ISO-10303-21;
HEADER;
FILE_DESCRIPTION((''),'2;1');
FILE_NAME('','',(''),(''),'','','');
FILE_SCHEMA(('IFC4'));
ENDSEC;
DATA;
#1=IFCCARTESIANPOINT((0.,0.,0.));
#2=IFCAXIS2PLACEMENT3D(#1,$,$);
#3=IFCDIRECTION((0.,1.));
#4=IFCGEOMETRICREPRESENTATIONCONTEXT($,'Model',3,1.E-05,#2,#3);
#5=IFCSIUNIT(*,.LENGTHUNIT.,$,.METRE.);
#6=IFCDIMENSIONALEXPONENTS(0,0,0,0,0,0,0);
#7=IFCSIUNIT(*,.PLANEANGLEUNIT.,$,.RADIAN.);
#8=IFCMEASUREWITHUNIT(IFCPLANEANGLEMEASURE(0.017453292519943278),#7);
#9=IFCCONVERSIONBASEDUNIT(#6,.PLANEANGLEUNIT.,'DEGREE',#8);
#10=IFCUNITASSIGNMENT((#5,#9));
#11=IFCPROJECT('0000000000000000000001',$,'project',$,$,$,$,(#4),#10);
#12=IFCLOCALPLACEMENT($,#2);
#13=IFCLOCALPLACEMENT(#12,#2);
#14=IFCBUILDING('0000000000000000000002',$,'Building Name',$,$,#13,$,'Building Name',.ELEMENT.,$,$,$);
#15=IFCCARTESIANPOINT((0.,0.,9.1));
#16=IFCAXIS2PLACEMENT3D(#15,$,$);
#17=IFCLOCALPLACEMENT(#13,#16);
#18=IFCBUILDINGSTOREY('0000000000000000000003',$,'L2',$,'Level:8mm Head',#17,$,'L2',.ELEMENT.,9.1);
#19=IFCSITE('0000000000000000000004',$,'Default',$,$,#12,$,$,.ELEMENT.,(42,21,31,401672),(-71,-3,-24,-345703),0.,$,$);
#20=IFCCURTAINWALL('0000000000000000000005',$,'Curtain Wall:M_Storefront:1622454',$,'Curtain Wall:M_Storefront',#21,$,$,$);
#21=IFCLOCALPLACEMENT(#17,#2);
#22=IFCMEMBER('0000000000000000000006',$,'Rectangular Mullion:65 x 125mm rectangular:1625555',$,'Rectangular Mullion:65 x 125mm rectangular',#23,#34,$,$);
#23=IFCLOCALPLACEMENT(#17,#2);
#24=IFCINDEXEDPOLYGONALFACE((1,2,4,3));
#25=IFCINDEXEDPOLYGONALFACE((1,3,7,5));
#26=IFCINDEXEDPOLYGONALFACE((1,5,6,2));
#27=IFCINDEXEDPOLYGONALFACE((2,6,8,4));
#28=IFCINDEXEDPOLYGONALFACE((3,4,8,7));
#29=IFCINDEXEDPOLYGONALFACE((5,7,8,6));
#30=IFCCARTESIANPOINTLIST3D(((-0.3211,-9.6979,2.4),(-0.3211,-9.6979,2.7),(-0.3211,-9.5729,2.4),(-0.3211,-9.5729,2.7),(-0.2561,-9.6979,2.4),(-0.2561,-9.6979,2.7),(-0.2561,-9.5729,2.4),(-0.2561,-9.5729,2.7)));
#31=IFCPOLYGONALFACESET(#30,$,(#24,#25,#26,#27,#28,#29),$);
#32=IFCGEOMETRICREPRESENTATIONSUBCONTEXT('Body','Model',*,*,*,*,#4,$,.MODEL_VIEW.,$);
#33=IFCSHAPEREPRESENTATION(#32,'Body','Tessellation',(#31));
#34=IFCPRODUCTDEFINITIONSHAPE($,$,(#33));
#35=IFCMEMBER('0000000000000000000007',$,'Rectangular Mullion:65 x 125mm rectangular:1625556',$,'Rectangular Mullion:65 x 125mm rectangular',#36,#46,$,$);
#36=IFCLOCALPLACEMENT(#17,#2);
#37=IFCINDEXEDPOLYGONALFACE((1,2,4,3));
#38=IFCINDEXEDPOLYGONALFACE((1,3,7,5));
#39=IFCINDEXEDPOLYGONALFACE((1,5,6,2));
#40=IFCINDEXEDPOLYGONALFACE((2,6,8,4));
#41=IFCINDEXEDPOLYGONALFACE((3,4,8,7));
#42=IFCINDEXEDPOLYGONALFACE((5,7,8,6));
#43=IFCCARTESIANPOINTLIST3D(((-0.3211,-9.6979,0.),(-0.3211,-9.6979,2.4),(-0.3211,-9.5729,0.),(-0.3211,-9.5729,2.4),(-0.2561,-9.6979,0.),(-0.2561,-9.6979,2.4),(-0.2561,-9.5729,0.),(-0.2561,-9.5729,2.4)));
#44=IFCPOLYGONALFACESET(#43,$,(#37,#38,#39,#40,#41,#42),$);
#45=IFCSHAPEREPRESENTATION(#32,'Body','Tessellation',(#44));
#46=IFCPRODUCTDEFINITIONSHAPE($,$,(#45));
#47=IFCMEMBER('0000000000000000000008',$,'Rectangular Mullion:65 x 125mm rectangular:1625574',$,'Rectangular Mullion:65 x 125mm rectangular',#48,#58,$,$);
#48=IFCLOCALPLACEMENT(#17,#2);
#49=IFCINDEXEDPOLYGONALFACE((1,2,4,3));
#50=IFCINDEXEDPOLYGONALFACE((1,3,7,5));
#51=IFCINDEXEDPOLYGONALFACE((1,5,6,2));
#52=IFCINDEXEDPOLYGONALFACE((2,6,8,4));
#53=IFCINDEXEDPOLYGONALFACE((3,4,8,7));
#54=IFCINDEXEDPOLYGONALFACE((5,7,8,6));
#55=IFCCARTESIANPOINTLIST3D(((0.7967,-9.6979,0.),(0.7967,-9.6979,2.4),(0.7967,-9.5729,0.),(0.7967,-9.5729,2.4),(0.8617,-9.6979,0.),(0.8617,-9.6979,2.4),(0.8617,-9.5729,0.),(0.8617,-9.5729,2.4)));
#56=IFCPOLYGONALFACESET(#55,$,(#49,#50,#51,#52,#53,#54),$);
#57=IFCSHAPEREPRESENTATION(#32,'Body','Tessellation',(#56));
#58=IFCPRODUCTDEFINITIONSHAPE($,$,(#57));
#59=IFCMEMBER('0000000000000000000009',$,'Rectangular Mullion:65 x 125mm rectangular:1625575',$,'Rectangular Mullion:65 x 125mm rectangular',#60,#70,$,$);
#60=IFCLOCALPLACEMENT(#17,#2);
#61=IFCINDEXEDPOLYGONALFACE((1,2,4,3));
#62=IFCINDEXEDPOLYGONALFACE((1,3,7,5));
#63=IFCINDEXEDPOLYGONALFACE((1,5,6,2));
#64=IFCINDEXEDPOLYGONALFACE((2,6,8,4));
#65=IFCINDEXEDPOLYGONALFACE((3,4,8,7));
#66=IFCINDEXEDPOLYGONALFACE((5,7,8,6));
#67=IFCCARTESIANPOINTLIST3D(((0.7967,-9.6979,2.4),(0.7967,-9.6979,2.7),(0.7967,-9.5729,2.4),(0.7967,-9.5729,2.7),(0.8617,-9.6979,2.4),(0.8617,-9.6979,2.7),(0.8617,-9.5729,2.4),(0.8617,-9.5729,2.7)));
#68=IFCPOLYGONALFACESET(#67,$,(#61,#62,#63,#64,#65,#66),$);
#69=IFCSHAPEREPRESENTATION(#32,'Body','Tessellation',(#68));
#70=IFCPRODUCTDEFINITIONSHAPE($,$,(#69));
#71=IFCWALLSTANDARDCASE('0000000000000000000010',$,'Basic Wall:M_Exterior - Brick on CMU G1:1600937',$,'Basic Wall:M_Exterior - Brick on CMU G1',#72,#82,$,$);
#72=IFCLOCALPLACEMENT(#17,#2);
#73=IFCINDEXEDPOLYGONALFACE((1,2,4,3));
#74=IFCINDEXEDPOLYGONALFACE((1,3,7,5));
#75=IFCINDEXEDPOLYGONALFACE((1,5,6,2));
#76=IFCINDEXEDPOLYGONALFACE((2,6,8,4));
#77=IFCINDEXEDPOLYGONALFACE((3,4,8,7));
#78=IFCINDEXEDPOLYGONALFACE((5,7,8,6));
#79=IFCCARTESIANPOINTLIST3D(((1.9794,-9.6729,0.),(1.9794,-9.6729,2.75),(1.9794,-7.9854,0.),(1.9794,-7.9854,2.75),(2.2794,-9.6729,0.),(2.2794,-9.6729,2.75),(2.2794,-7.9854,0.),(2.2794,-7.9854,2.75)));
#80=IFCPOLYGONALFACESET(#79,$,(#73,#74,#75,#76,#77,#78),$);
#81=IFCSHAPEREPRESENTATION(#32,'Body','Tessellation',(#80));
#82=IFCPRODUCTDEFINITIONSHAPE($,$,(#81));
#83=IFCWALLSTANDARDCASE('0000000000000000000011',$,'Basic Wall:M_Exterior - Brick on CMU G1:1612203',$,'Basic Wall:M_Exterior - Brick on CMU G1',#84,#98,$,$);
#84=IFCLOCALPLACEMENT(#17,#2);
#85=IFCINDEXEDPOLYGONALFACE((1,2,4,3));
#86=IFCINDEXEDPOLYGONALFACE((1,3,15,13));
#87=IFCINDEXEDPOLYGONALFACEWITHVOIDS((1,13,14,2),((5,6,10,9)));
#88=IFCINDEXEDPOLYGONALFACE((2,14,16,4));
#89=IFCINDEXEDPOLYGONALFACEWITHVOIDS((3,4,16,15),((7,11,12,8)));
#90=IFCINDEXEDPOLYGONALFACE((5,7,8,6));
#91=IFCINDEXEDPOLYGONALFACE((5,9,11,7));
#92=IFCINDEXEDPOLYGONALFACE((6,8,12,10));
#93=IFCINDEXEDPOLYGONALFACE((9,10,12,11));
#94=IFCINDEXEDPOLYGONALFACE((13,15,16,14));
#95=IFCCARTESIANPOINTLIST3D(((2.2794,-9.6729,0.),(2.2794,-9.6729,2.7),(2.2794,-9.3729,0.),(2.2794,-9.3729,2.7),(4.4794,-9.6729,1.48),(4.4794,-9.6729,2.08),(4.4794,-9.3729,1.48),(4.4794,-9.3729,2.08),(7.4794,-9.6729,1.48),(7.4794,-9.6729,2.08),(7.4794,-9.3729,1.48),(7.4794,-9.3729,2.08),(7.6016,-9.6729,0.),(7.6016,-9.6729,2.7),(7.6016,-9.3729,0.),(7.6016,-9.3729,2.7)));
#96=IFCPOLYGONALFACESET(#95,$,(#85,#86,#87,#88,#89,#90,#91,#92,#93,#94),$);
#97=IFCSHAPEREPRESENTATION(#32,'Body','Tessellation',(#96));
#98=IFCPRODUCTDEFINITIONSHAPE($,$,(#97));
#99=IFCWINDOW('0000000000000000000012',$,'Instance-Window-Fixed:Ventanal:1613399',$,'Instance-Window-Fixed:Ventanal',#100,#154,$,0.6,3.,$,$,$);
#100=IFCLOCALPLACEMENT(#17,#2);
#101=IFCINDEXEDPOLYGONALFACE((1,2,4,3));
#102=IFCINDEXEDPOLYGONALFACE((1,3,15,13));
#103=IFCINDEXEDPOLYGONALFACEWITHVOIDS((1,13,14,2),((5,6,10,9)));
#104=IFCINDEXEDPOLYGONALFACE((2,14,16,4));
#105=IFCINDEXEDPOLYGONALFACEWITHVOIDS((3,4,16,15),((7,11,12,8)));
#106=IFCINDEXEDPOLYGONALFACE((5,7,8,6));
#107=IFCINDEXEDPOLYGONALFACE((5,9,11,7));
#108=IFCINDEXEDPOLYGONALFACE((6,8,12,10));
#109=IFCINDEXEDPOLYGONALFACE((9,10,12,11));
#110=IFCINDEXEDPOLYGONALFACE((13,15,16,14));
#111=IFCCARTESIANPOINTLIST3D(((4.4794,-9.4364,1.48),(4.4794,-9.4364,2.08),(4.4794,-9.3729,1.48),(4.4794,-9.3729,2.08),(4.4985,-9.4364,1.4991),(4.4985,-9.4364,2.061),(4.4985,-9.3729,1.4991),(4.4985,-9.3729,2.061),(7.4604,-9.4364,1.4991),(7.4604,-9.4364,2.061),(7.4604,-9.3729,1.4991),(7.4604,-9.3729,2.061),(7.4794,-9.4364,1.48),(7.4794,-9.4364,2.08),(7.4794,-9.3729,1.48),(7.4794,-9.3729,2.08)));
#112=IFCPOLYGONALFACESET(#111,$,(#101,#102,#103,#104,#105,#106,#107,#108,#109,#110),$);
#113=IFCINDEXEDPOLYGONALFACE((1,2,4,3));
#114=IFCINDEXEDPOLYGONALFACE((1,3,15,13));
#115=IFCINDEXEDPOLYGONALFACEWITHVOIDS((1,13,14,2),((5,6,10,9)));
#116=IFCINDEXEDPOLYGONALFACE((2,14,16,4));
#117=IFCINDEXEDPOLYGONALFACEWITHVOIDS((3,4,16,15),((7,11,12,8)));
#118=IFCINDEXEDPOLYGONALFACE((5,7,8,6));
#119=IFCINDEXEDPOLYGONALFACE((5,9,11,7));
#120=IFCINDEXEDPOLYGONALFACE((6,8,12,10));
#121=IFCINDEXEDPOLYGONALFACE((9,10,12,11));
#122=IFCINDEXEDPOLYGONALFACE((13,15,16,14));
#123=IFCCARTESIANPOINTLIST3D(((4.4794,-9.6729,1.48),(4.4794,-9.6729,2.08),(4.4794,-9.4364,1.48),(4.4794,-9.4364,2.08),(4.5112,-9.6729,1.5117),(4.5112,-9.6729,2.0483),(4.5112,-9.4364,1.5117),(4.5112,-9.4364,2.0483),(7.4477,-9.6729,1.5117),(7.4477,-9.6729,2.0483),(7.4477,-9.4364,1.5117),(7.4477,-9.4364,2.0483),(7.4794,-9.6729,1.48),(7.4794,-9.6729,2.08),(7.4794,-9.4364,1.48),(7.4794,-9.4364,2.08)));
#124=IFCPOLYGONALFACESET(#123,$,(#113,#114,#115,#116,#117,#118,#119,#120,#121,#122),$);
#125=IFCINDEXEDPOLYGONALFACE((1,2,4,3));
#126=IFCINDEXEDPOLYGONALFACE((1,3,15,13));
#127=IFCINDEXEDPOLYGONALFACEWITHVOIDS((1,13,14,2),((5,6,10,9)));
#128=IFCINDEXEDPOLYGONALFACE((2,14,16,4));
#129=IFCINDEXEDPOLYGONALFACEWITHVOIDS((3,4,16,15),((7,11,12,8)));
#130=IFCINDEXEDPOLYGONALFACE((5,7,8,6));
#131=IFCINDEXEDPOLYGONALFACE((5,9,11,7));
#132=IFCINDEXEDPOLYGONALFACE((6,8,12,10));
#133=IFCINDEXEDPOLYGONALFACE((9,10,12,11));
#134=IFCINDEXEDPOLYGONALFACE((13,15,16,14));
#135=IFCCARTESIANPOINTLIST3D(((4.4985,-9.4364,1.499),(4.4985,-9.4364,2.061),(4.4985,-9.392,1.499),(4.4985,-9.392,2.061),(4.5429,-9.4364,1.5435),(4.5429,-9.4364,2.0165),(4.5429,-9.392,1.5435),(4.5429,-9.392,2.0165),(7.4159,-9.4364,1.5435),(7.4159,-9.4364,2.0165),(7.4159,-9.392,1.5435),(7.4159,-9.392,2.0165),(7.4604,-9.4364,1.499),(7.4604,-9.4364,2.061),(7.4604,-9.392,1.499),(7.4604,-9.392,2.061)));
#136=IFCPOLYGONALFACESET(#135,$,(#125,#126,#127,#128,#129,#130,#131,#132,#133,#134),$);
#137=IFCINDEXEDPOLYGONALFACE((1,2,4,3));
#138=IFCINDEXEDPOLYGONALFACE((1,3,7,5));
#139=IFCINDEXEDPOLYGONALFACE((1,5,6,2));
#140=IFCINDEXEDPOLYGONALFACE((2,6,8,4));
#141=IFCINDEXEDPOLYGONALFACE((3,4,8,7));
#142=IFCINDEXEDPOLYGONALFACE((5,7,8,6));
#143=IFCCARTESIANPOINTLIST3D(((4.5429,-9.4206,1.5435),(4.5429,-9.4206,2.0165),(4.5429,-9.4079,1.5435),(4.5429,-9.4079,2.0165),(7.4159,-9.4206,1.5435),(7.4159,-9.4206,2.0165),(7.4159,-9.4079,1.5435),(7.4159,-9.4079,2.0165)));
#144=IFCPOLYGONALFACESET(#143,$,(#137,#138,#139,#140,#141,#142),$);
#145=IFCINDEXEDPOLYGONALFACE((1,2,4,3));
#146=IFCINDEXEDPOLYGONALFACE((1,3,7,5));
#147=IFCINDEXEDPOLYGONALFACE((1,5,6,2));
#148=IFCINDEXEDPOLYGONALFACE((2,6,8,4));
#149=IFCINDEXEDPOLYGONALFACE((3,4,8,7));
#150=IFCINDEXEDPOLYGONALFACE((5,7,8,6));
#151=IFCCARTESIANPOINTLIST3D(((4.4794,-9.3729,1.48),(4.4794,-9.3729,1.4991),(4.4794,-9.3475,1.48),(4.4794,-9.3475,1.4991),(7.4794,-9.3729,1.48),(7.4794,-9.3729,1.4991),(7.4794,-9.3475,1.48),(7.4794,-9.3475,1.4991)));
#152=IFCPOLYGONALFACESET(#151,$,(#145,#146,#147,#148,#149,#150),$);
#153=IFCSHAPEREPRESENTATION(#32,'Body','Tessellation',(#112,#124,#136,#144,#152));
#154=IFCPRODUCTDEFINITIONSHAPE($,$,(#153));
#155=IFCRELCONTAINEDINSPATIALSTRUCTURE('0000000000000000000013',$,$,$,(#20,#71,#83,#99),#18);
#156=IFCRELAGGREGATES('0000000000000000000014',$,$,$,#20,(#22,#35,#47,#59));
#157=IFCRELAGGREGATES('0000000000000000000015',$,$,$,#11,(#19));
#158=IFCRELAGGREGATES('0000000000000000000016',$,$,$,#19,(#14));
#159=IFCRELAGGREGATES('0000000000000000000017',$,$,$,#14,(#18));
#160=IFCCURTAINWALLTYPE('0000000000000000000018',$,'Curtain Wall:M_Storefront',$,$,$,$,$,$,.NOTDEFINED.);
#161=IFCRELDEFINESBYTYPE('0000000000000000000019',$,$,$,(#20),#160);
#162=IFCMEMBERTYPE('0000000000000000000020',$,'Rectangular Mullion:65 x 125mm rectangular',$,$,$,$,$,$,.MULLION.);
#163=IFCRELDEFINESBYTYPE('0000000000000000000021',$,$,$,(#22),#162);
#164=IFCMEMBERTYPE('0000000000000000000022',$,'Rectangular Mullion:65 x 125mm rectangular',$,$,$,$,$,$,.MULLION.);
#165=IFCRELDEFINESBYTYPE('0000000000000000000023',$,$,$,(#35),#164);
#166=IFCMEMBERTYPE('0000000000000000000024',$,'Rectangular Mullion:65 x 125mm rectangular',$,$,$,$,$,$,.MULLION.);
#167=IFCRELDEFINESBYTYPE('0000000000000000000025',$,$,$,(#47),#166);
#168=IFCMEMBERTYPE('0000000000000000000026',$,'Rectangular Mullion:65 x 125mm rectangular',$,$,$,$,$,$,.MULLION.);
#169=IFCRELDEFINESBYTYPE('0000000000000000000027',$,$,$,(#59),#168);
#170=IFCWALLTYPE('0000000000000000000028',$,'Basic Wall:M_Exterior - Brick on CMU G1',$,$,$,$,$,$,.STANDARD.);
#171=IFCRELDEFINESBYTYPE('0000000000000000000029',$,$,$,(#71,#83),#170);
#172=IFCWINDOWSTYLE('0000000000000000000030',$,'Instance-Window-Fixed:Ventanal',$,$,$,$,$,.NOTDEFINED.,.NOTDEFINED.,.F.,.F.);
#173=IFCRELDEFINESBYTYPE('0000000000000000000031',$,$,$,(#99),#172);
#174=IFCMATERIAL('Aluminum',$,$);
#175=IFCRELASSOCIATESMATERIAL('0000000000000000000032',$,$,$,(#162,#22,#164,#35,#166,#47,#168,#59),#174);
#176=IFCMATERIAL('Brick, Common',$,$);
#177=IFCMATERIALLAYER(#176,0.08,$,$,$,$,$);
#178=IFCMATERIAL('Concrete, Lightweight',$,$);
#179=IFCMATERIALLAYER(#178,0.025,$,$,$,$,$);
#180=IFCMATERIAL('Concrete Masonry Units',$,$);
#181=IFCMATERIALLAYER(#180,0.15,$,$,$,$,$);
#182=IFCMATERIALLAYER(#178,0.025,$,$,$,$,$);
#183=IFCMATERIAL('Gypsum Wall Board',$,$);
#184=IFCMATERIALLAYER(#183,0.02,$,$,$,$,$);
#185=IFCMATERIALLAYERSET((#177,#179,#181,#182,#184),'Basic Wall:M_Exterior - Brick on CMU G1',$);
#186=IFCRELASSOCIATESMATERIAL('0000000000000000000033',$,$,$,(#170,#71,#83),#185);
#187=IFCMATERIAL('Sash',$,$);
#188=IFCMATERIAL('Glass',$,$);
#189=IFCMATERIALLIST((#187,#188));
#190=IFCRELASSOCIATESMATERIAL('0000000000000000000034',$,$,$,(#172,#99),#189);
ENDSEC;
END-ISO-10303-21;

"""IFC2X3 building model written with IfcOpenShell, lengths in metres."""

from ifc_helpers import new_model, entity, si_unit, converted_unit, direction, frame, frame_2d, origin, origin_2d_with_axis, place, context, subcontext, project, spatial, polyline, rectangle, outline, extrude, source, transform, mapped, material, material_list, layer, layer_set, layer_usage, type_object, type_shapes, element, fill, aggregate, save


model = new_model("IFC2X3")

# Units and contexts
model_context = context("Model", 3, precision=1e-05, world=origin(), true_north=direction((0.0, 1.0)))
body_context = subcontext(model_context, "Body", "Model", "MODEL_VIEW")
ifc_project = project(units=[si_unit("LENGTHUNIT", "METRE"), converted_unit("PLANEANGLEUNIT", "DEGREE", entity("IfcPlaneAngleMeasure", 0.017453292519943278), si_unit("PLANEANGLEUNIT", "RADIAN"), dimensions=[0, 0, 0, 0, 0, 0, 0])], contexts=[model_context])

# Site, building, storey
site_placement = place(None, origin())
site = spatial("IfcSite", under=ifc_project, at=site_placement, Name="Default", CompositionType="ELEMENT", RefLatitude=(42, 21, 31, 401672), RefLongitude=(-71, -3, -24, -345703), RefElevation=0.0)
building_placement = place(site_placement, origin())
building = spatial("IfcBuilding", under=site, at=building_placement, Name="Building Name", LongName="Building Name", CompositionType="ELEMENT")
storey_placement = place(building_placement, frame((0.0, 0.0, 9.1)))
storey = spatial("IfcBuildingStorey", under=building, at=storey_placement, Name="L2", ObjectType="Level:8mm Head", LongName="L2", CompositionType="ELEMENT", Elevation=9.1)

# Shared definitions
ifc_material_1 = material(Name="Aluminum")

# Curtain wall, members
curtain_wall_type_1 = type_object("IfcCurtainWallType", Name="Curtain Wall:M_Storefront", PredefinedType="NOTDEFINED")
curtain_wall_1_placement = place(storey_placement, frame((0.0, 0.0, -9.1)))
curtain_wall_1 = element("IfcCurtainWall", 1, at=curtain_wall_1_placement, inside=storey, type_object=curtain_wall_type_1, Name="Curtain Wall:M_Storefront:1622454", ObjectType="Curtain Wall:M_Storefront")
member_type_1 = type_object("IfcMemberType", Name="Rectangular Mullion:65 x 125mm rectangular", PredefinedType="MULLION", material=ifc_material_1)
shared_shape_1 = source(origin(), body_context, "Body", "SweptSolid", [
    extrude(rectangle(XDim=0.065, YDim=0.125, at=origin_2d_with_axis()), frame((-0.0325, 0.0, -0.3), z_axis=(0.0, 0.0, 1.0), x_axis=(-1.0, 0.0, 0.0)), (0.0, 0.0, 1.0), 0.3),
])
type_shapes(member_type_1, [shared_shape_1])
member_1_placement = place(curtain_wall_1_placement, frame((-0.3211, -9.6354, 11.8), z_axis=(0.0, 0.0, 1.0), x_axis=(-1.0, 0.0, 0.0)))
member_1 = element("IfcMember", 2, at=member_1_placement, type_object=member_type_1, material=ifc_material_1, Name="Rectangular Mullion:65 x 125mm rectangular:1625555", ObjectType="Rectangular Mullion:65 x 125mm rectangular", context=body_context, shape_type="MappedRepresentation", body=[
    mapped(shared_shape_1, transform((0.0, 0.0, 0.0), scale=1.0)),
])
member_type_2 = type_object("IfcMemberType", Name="Rectangular Mullion:65 x 125mm rectangular", PredefinedType="MULLION", material=ifc_material_1)
shared_shape_2 = source(origin(), body_context, "Body", "SweptSolid", [
    extrude(rectangle(XDim=0.065, YDim=0.125, at=origin_2d_with_axis()), frame((-0.0325, 0.0, -2.4), z_axis=(0.0, 0.0, 1.0), x_axis=(-1.0, 0.0, 0.0)), (0.0, 0.0, 1.0), 2.4),
])
type_shapes(member_type_2, [shared_shape_2])
member_2_placement = place(curtain_wall_1_placement, frame((-0.3211, -9.6354, 11.5), z_axis=(0.0, 0.0, 1.0), x_axis=(-1.0, 0.0, 0.0)))
member_2 = element("IfcMember", 3, at=member_2_placement, type_object=member_type_2, material=ifc_material_1, Name="Rectangular Mullion:65 x 125mm rectangular:1625556", ObjectType="Rectangular Mullion:65 x 125mm rectangular", context=body_context, shape_type="MappedRepresentation", body=[
    mapped(shared_shape_2, transform((0.0, 0.0, 0.0), scale=1.0)),
])
member_type_3 = type_object("IfcMemberType", Name="Rectangular Mullion:65 x 125mm rectangular", PredefinedType="MULLION", material=ifc_material_1)
shared_shape_3 = source(origin(), body_context, "Body", "SweptSolid", [
    extrude(rectangle(XDim=0.065, YDim=0.125, at=origin_2d_with_axis()), frame((0.0, 0.0, -2.4), z_axis=(0.0, 0.0, 1.0), x_axis=(-1.0, 0.0, 0.0)), (0.0, 0.0, 1.0), 2.4),
])
type_shapes(member_type_3, [shared_shape_3])
member_3_placement = place(curtain_wall_1_placement, frame((0.8292, -9.6354, 9.1), z_axis=(0.0, 0.0, -1.0), x_axis=(1.0, 0.0, 0.0)))
member_3 = element("IfcMember", 4, at=member_3_placement, type_object=member_type_3, material=ifc_material_1, Name="Rectangular Mullion:65 x 125mm rectangular:1625574", ObjectType="Rectangular Mullion:65 x 125mm rectangular", context=body_context, shape_type="MappedRepresentation", body=[
    mapped(shared_shape_3, transform((0.0, 0.0, 0.0), scale=1.0)),
])
member_type_4 = type_object("IfcMemberType", Name="Rectangular Mullion:65 x 125mm rectangular", PredefinedType="MULLION", material=ifc_material_1)
shared_shape_4 = source(origin(), body_context, "Body", "SweptSolid", [
    extrude(rectangle(XDim=0.065, YDim=0.125, at=origin_2d_with_axis()), frame((0.0, 0.0, -0.3), z_axis=(0.0, 0.0, 1.0), x_axis=(-1.0, 0.0, 0.0)), (0.0, 0.0, 1.0), 0.3),
])
type_shapes(member_type_4, [shared_shape_4])
member_4_placement = place(curtain_wall_1_placement, frame((0.8292, -9.6354, 11.5), z_axis=(0.0, 0.0, -1.0), x_axis=(1.0, 0.0, 0.0)))
member_4 = element("IfcMember", 5, at=member_4_placement, type_object=member_type_4, material=ifc_material_1, Name="Rectangular Mullion:65 x 125mm rectangular:1625575", ObjectType="Rectangular Mullion:65 x 125mm rectangular", context=body_context, shape_type="MappedRepresentation", body=[
    mapped(shared_shape_4, transform((0.0, 0.0, 0.0), scale=1.0)),
])

# Shared definitions
ifc_material_2 = material(Name="Glass")
aggregate(curtain_wall_1, [member_1, member_2, member_3, member_4])

# Wall
ifc_material_3 = material(Name="Brick, Common")
ifc_layer_1 = layer(ifc_material_3, 0.08)
ifc_material_4 = material(Name="Concrete, Lightweight")
ifc_layer_2 = layer(ifc_material_4, 0.025)
ifc_material_5 = material(Name="Concrete Masonry Units")
ifc_layer_3 = layer(ifc_material_5, 0.15)
ifc_layer_4 = layer(ifc_material_4, 0.025)
ifc_material_6 = material(Name="Gypsum Wall Board")
ifc_layer_5 = layer(ifc_material_6, 0.02)
ifc_layer_set = layer_set([ifc_layer_1, ifc_layer_2, ifc_layer_3, ifc_layer_4, ifc_layer_5], Name="Basic Wall:M_Exterior - Brick on CMU G1")
ifc_layer_usage_1 = layer_usage(ifc_layer_set, "AXIS2", "POSITIVE", -0.15)
wall_type = type_object("IfcWallType", Name="Basic Wall:M_Exterior - Brick on CMU G1", PredefinedType="STANDARD", material=ifc_layer_set)
wall_1_placement = place(storey_placement, frame((2.1294, -9.6729, 0.0), z_axis=(0.0, 0.0, 1.0), x_axis=(0.0, 1.0, 0.0)))
element("IfcWallStandardCase", 6, at=wall_1_placement, inside=storey, type_object=wall_type, material=ifc_layer_usage_1, Name="Basic Wall:M_Exterior - Brick on CMU G1:1600937", ObjectType="Basic Wall:M_Exterior - Brick on CMU G1", context=body_context, shape_type="SweptSolid", body=[
    extrude(rectangle(XDim=1.6875, YDim=0.3, at=frame_2d((0.8438, 0.0), x_axis=(-1.0, 0.0))), origin(), (0.0, 0.0, 1.0), 2.75),
])

# Wall, opening, window
ifc_layer_usage_2 = layer_usage(ifc_layer_set, "AXIS2", "POSITIVE", -0.15)
wall_2_placement = place(storey_placement, frame((2.2794, -9.5229, 0.0)))
wall_2 = element("IfcWallStandardCase", 7, at=wall_2_placement, inside=storey, type_object=wall_type, material=ifc_layer_usage_2, Name="Basic Wall:M_Exterior - Brick on CMU G1:1612203", ObjectType="Basic Wall:M_Exterior - Brick on CMU G1", context=body_context, shape_type="SweptSolid", body=[
    extrude(rectangle(XDim=5.3222, YDim=0.3, at=frame_2d((2.6611, 0.0), x_axis=(-1.0, 0.0))), origin(), (0.0, 0.0, 1.0), 2.7),
])
opening_placement = place(wall_2_placement, frame((2.2, -0.15, 1.48)))
opening = element("IfcOpeningElement", 8, at=opening_placement, cuts=wall_2, ObjectType="Opening", context=body_context, shape_type="SweptSolid", body=[
    extrude(rectangle(XDim=0.6, YDim=3.0, at=frame_2d((0.3, 1.5), x_axis=(-1.0, 0.0))), frame((0.0, 0.0, 0.0), z_axis=(0.0, 1.0, 0.0), x_axis=(0.0, 0.0, 1.0)), (0.0, 0.0, 1.0), 0.3),
])
ifc_material_7 = material(Name="Sash")
ifc_material_list = material_list([ifc_material_7, ifc_material_2])
window_style = type_object("IfcWindowStyle", Name="Instance-Window-Fixed:Ventanal", ConstructionType="NOTDEFINED", OperationType="NOTDEFINED", ParameterTakesPrecedence=False, Sizeable=False, material=ifc_material_list)
shared_shape_5 = source(origin(), body_context, "Body", "SweptSolid", [
    extrude(outline(polyline([(-0.3, -1.5), (0.3, -1.5), (0.3, 1.5), (-0.3, 1.5), (-0.3, -1.5)]), holes=[polyline([(-0.2809, -1.4809), (-0.2809, 1.481), (0.281, 1.481), (0.281, -1.4809), (-0.2809, -1.4809)])]), frame((1.5, 0.2365, 0.3), z_axis=(0.0, 1.0, 0.0), x_axis=(0.0, 0.0, -1.0)), (0.0, 0.0, 1.0), 0.0635),
    extrude(outline(polyline([(-1.5, -0.3), (1.5, -0.3), (1.5, 0.3), (-1.5, 0.3), (-1.5, -0.3)]), holes=[polyline([(-1.4682, -0.2682), (-1.4682, 0.2683), (1.4682, 0.2683), (1.4682, -0.2682), (-1.4682, -0.2682)])]), frame((1.5, 0.0, 0.3), z_axis=(0.0, 1.0, 0.0), x_axis=(1.0, 0.0, 0.0)), (0.0, 0.0, 1.0), 0.2365),
    extrude(outline(polyline([(-1.4809, -0.281), (1.4809, -0.281), (1.4809, 0.281), (-1.4809, 0.281), (-1.4809, -0.281)]), holes=[polyline([(-1.4365, -0.2365), (-1.4365, 0.2365), (1.4365, 0.2365), (1.4365, -0.2365), (-1.4365, -0.2365)])]), frame((1.5, 0.2365, 0.3), z_axis=(0.0, 1.0, 0.0), x_axis=(1.0, 0.0, 0.0)), (0.0, 0.0, 1.0), 0.0444),
    extrude(rectangle(XDim=0.0127, YDim=2.873, at=frame_2d((0.0, 0.0), x_axis=(1.0, 0.0))), frame((1.5, 0.2587, 0.0635), z_axis=(0.0, 0.0, 1.0), x_axis=(0.0, 1.0, 0.0)), (0.0, 0.0, 1.0), 0.473),
    extrude(rectangle(XDim=0.0254, YDim=3.0, at=frame_2d((0.0, 0.0), x_axis=(1.0, 0.0))), frame((1.5, 0.3127, 0.0), z_axis=(0.0, 0.0, 1.0), x_axis=(0.0, -1.0, 0.0)), (0.0, 0.0, 1.0), 0.019),
])
type_shapes(window_style, [shared_shape_5])
window_placement = place(opening_placement, origin())
window = element("IfcWindow", 9, at=window_placement, inside=storey, type_object=window_style, material=ifc_material_list, Name="Instance-Window-Fixed:Ventanal:1613399", ObjectType="Instance-Window-Fixed:Ventanal", OverallHeight=0.6, OverallWidth=3.0, context=body_context, shape_type="MappedRepresentation", body=[
    mapped(shared_shape_5, transform((0.0, 0.0, 0.0), scale=1.0)),
])
fill(opening, window)

save(model, "model.ifc")
